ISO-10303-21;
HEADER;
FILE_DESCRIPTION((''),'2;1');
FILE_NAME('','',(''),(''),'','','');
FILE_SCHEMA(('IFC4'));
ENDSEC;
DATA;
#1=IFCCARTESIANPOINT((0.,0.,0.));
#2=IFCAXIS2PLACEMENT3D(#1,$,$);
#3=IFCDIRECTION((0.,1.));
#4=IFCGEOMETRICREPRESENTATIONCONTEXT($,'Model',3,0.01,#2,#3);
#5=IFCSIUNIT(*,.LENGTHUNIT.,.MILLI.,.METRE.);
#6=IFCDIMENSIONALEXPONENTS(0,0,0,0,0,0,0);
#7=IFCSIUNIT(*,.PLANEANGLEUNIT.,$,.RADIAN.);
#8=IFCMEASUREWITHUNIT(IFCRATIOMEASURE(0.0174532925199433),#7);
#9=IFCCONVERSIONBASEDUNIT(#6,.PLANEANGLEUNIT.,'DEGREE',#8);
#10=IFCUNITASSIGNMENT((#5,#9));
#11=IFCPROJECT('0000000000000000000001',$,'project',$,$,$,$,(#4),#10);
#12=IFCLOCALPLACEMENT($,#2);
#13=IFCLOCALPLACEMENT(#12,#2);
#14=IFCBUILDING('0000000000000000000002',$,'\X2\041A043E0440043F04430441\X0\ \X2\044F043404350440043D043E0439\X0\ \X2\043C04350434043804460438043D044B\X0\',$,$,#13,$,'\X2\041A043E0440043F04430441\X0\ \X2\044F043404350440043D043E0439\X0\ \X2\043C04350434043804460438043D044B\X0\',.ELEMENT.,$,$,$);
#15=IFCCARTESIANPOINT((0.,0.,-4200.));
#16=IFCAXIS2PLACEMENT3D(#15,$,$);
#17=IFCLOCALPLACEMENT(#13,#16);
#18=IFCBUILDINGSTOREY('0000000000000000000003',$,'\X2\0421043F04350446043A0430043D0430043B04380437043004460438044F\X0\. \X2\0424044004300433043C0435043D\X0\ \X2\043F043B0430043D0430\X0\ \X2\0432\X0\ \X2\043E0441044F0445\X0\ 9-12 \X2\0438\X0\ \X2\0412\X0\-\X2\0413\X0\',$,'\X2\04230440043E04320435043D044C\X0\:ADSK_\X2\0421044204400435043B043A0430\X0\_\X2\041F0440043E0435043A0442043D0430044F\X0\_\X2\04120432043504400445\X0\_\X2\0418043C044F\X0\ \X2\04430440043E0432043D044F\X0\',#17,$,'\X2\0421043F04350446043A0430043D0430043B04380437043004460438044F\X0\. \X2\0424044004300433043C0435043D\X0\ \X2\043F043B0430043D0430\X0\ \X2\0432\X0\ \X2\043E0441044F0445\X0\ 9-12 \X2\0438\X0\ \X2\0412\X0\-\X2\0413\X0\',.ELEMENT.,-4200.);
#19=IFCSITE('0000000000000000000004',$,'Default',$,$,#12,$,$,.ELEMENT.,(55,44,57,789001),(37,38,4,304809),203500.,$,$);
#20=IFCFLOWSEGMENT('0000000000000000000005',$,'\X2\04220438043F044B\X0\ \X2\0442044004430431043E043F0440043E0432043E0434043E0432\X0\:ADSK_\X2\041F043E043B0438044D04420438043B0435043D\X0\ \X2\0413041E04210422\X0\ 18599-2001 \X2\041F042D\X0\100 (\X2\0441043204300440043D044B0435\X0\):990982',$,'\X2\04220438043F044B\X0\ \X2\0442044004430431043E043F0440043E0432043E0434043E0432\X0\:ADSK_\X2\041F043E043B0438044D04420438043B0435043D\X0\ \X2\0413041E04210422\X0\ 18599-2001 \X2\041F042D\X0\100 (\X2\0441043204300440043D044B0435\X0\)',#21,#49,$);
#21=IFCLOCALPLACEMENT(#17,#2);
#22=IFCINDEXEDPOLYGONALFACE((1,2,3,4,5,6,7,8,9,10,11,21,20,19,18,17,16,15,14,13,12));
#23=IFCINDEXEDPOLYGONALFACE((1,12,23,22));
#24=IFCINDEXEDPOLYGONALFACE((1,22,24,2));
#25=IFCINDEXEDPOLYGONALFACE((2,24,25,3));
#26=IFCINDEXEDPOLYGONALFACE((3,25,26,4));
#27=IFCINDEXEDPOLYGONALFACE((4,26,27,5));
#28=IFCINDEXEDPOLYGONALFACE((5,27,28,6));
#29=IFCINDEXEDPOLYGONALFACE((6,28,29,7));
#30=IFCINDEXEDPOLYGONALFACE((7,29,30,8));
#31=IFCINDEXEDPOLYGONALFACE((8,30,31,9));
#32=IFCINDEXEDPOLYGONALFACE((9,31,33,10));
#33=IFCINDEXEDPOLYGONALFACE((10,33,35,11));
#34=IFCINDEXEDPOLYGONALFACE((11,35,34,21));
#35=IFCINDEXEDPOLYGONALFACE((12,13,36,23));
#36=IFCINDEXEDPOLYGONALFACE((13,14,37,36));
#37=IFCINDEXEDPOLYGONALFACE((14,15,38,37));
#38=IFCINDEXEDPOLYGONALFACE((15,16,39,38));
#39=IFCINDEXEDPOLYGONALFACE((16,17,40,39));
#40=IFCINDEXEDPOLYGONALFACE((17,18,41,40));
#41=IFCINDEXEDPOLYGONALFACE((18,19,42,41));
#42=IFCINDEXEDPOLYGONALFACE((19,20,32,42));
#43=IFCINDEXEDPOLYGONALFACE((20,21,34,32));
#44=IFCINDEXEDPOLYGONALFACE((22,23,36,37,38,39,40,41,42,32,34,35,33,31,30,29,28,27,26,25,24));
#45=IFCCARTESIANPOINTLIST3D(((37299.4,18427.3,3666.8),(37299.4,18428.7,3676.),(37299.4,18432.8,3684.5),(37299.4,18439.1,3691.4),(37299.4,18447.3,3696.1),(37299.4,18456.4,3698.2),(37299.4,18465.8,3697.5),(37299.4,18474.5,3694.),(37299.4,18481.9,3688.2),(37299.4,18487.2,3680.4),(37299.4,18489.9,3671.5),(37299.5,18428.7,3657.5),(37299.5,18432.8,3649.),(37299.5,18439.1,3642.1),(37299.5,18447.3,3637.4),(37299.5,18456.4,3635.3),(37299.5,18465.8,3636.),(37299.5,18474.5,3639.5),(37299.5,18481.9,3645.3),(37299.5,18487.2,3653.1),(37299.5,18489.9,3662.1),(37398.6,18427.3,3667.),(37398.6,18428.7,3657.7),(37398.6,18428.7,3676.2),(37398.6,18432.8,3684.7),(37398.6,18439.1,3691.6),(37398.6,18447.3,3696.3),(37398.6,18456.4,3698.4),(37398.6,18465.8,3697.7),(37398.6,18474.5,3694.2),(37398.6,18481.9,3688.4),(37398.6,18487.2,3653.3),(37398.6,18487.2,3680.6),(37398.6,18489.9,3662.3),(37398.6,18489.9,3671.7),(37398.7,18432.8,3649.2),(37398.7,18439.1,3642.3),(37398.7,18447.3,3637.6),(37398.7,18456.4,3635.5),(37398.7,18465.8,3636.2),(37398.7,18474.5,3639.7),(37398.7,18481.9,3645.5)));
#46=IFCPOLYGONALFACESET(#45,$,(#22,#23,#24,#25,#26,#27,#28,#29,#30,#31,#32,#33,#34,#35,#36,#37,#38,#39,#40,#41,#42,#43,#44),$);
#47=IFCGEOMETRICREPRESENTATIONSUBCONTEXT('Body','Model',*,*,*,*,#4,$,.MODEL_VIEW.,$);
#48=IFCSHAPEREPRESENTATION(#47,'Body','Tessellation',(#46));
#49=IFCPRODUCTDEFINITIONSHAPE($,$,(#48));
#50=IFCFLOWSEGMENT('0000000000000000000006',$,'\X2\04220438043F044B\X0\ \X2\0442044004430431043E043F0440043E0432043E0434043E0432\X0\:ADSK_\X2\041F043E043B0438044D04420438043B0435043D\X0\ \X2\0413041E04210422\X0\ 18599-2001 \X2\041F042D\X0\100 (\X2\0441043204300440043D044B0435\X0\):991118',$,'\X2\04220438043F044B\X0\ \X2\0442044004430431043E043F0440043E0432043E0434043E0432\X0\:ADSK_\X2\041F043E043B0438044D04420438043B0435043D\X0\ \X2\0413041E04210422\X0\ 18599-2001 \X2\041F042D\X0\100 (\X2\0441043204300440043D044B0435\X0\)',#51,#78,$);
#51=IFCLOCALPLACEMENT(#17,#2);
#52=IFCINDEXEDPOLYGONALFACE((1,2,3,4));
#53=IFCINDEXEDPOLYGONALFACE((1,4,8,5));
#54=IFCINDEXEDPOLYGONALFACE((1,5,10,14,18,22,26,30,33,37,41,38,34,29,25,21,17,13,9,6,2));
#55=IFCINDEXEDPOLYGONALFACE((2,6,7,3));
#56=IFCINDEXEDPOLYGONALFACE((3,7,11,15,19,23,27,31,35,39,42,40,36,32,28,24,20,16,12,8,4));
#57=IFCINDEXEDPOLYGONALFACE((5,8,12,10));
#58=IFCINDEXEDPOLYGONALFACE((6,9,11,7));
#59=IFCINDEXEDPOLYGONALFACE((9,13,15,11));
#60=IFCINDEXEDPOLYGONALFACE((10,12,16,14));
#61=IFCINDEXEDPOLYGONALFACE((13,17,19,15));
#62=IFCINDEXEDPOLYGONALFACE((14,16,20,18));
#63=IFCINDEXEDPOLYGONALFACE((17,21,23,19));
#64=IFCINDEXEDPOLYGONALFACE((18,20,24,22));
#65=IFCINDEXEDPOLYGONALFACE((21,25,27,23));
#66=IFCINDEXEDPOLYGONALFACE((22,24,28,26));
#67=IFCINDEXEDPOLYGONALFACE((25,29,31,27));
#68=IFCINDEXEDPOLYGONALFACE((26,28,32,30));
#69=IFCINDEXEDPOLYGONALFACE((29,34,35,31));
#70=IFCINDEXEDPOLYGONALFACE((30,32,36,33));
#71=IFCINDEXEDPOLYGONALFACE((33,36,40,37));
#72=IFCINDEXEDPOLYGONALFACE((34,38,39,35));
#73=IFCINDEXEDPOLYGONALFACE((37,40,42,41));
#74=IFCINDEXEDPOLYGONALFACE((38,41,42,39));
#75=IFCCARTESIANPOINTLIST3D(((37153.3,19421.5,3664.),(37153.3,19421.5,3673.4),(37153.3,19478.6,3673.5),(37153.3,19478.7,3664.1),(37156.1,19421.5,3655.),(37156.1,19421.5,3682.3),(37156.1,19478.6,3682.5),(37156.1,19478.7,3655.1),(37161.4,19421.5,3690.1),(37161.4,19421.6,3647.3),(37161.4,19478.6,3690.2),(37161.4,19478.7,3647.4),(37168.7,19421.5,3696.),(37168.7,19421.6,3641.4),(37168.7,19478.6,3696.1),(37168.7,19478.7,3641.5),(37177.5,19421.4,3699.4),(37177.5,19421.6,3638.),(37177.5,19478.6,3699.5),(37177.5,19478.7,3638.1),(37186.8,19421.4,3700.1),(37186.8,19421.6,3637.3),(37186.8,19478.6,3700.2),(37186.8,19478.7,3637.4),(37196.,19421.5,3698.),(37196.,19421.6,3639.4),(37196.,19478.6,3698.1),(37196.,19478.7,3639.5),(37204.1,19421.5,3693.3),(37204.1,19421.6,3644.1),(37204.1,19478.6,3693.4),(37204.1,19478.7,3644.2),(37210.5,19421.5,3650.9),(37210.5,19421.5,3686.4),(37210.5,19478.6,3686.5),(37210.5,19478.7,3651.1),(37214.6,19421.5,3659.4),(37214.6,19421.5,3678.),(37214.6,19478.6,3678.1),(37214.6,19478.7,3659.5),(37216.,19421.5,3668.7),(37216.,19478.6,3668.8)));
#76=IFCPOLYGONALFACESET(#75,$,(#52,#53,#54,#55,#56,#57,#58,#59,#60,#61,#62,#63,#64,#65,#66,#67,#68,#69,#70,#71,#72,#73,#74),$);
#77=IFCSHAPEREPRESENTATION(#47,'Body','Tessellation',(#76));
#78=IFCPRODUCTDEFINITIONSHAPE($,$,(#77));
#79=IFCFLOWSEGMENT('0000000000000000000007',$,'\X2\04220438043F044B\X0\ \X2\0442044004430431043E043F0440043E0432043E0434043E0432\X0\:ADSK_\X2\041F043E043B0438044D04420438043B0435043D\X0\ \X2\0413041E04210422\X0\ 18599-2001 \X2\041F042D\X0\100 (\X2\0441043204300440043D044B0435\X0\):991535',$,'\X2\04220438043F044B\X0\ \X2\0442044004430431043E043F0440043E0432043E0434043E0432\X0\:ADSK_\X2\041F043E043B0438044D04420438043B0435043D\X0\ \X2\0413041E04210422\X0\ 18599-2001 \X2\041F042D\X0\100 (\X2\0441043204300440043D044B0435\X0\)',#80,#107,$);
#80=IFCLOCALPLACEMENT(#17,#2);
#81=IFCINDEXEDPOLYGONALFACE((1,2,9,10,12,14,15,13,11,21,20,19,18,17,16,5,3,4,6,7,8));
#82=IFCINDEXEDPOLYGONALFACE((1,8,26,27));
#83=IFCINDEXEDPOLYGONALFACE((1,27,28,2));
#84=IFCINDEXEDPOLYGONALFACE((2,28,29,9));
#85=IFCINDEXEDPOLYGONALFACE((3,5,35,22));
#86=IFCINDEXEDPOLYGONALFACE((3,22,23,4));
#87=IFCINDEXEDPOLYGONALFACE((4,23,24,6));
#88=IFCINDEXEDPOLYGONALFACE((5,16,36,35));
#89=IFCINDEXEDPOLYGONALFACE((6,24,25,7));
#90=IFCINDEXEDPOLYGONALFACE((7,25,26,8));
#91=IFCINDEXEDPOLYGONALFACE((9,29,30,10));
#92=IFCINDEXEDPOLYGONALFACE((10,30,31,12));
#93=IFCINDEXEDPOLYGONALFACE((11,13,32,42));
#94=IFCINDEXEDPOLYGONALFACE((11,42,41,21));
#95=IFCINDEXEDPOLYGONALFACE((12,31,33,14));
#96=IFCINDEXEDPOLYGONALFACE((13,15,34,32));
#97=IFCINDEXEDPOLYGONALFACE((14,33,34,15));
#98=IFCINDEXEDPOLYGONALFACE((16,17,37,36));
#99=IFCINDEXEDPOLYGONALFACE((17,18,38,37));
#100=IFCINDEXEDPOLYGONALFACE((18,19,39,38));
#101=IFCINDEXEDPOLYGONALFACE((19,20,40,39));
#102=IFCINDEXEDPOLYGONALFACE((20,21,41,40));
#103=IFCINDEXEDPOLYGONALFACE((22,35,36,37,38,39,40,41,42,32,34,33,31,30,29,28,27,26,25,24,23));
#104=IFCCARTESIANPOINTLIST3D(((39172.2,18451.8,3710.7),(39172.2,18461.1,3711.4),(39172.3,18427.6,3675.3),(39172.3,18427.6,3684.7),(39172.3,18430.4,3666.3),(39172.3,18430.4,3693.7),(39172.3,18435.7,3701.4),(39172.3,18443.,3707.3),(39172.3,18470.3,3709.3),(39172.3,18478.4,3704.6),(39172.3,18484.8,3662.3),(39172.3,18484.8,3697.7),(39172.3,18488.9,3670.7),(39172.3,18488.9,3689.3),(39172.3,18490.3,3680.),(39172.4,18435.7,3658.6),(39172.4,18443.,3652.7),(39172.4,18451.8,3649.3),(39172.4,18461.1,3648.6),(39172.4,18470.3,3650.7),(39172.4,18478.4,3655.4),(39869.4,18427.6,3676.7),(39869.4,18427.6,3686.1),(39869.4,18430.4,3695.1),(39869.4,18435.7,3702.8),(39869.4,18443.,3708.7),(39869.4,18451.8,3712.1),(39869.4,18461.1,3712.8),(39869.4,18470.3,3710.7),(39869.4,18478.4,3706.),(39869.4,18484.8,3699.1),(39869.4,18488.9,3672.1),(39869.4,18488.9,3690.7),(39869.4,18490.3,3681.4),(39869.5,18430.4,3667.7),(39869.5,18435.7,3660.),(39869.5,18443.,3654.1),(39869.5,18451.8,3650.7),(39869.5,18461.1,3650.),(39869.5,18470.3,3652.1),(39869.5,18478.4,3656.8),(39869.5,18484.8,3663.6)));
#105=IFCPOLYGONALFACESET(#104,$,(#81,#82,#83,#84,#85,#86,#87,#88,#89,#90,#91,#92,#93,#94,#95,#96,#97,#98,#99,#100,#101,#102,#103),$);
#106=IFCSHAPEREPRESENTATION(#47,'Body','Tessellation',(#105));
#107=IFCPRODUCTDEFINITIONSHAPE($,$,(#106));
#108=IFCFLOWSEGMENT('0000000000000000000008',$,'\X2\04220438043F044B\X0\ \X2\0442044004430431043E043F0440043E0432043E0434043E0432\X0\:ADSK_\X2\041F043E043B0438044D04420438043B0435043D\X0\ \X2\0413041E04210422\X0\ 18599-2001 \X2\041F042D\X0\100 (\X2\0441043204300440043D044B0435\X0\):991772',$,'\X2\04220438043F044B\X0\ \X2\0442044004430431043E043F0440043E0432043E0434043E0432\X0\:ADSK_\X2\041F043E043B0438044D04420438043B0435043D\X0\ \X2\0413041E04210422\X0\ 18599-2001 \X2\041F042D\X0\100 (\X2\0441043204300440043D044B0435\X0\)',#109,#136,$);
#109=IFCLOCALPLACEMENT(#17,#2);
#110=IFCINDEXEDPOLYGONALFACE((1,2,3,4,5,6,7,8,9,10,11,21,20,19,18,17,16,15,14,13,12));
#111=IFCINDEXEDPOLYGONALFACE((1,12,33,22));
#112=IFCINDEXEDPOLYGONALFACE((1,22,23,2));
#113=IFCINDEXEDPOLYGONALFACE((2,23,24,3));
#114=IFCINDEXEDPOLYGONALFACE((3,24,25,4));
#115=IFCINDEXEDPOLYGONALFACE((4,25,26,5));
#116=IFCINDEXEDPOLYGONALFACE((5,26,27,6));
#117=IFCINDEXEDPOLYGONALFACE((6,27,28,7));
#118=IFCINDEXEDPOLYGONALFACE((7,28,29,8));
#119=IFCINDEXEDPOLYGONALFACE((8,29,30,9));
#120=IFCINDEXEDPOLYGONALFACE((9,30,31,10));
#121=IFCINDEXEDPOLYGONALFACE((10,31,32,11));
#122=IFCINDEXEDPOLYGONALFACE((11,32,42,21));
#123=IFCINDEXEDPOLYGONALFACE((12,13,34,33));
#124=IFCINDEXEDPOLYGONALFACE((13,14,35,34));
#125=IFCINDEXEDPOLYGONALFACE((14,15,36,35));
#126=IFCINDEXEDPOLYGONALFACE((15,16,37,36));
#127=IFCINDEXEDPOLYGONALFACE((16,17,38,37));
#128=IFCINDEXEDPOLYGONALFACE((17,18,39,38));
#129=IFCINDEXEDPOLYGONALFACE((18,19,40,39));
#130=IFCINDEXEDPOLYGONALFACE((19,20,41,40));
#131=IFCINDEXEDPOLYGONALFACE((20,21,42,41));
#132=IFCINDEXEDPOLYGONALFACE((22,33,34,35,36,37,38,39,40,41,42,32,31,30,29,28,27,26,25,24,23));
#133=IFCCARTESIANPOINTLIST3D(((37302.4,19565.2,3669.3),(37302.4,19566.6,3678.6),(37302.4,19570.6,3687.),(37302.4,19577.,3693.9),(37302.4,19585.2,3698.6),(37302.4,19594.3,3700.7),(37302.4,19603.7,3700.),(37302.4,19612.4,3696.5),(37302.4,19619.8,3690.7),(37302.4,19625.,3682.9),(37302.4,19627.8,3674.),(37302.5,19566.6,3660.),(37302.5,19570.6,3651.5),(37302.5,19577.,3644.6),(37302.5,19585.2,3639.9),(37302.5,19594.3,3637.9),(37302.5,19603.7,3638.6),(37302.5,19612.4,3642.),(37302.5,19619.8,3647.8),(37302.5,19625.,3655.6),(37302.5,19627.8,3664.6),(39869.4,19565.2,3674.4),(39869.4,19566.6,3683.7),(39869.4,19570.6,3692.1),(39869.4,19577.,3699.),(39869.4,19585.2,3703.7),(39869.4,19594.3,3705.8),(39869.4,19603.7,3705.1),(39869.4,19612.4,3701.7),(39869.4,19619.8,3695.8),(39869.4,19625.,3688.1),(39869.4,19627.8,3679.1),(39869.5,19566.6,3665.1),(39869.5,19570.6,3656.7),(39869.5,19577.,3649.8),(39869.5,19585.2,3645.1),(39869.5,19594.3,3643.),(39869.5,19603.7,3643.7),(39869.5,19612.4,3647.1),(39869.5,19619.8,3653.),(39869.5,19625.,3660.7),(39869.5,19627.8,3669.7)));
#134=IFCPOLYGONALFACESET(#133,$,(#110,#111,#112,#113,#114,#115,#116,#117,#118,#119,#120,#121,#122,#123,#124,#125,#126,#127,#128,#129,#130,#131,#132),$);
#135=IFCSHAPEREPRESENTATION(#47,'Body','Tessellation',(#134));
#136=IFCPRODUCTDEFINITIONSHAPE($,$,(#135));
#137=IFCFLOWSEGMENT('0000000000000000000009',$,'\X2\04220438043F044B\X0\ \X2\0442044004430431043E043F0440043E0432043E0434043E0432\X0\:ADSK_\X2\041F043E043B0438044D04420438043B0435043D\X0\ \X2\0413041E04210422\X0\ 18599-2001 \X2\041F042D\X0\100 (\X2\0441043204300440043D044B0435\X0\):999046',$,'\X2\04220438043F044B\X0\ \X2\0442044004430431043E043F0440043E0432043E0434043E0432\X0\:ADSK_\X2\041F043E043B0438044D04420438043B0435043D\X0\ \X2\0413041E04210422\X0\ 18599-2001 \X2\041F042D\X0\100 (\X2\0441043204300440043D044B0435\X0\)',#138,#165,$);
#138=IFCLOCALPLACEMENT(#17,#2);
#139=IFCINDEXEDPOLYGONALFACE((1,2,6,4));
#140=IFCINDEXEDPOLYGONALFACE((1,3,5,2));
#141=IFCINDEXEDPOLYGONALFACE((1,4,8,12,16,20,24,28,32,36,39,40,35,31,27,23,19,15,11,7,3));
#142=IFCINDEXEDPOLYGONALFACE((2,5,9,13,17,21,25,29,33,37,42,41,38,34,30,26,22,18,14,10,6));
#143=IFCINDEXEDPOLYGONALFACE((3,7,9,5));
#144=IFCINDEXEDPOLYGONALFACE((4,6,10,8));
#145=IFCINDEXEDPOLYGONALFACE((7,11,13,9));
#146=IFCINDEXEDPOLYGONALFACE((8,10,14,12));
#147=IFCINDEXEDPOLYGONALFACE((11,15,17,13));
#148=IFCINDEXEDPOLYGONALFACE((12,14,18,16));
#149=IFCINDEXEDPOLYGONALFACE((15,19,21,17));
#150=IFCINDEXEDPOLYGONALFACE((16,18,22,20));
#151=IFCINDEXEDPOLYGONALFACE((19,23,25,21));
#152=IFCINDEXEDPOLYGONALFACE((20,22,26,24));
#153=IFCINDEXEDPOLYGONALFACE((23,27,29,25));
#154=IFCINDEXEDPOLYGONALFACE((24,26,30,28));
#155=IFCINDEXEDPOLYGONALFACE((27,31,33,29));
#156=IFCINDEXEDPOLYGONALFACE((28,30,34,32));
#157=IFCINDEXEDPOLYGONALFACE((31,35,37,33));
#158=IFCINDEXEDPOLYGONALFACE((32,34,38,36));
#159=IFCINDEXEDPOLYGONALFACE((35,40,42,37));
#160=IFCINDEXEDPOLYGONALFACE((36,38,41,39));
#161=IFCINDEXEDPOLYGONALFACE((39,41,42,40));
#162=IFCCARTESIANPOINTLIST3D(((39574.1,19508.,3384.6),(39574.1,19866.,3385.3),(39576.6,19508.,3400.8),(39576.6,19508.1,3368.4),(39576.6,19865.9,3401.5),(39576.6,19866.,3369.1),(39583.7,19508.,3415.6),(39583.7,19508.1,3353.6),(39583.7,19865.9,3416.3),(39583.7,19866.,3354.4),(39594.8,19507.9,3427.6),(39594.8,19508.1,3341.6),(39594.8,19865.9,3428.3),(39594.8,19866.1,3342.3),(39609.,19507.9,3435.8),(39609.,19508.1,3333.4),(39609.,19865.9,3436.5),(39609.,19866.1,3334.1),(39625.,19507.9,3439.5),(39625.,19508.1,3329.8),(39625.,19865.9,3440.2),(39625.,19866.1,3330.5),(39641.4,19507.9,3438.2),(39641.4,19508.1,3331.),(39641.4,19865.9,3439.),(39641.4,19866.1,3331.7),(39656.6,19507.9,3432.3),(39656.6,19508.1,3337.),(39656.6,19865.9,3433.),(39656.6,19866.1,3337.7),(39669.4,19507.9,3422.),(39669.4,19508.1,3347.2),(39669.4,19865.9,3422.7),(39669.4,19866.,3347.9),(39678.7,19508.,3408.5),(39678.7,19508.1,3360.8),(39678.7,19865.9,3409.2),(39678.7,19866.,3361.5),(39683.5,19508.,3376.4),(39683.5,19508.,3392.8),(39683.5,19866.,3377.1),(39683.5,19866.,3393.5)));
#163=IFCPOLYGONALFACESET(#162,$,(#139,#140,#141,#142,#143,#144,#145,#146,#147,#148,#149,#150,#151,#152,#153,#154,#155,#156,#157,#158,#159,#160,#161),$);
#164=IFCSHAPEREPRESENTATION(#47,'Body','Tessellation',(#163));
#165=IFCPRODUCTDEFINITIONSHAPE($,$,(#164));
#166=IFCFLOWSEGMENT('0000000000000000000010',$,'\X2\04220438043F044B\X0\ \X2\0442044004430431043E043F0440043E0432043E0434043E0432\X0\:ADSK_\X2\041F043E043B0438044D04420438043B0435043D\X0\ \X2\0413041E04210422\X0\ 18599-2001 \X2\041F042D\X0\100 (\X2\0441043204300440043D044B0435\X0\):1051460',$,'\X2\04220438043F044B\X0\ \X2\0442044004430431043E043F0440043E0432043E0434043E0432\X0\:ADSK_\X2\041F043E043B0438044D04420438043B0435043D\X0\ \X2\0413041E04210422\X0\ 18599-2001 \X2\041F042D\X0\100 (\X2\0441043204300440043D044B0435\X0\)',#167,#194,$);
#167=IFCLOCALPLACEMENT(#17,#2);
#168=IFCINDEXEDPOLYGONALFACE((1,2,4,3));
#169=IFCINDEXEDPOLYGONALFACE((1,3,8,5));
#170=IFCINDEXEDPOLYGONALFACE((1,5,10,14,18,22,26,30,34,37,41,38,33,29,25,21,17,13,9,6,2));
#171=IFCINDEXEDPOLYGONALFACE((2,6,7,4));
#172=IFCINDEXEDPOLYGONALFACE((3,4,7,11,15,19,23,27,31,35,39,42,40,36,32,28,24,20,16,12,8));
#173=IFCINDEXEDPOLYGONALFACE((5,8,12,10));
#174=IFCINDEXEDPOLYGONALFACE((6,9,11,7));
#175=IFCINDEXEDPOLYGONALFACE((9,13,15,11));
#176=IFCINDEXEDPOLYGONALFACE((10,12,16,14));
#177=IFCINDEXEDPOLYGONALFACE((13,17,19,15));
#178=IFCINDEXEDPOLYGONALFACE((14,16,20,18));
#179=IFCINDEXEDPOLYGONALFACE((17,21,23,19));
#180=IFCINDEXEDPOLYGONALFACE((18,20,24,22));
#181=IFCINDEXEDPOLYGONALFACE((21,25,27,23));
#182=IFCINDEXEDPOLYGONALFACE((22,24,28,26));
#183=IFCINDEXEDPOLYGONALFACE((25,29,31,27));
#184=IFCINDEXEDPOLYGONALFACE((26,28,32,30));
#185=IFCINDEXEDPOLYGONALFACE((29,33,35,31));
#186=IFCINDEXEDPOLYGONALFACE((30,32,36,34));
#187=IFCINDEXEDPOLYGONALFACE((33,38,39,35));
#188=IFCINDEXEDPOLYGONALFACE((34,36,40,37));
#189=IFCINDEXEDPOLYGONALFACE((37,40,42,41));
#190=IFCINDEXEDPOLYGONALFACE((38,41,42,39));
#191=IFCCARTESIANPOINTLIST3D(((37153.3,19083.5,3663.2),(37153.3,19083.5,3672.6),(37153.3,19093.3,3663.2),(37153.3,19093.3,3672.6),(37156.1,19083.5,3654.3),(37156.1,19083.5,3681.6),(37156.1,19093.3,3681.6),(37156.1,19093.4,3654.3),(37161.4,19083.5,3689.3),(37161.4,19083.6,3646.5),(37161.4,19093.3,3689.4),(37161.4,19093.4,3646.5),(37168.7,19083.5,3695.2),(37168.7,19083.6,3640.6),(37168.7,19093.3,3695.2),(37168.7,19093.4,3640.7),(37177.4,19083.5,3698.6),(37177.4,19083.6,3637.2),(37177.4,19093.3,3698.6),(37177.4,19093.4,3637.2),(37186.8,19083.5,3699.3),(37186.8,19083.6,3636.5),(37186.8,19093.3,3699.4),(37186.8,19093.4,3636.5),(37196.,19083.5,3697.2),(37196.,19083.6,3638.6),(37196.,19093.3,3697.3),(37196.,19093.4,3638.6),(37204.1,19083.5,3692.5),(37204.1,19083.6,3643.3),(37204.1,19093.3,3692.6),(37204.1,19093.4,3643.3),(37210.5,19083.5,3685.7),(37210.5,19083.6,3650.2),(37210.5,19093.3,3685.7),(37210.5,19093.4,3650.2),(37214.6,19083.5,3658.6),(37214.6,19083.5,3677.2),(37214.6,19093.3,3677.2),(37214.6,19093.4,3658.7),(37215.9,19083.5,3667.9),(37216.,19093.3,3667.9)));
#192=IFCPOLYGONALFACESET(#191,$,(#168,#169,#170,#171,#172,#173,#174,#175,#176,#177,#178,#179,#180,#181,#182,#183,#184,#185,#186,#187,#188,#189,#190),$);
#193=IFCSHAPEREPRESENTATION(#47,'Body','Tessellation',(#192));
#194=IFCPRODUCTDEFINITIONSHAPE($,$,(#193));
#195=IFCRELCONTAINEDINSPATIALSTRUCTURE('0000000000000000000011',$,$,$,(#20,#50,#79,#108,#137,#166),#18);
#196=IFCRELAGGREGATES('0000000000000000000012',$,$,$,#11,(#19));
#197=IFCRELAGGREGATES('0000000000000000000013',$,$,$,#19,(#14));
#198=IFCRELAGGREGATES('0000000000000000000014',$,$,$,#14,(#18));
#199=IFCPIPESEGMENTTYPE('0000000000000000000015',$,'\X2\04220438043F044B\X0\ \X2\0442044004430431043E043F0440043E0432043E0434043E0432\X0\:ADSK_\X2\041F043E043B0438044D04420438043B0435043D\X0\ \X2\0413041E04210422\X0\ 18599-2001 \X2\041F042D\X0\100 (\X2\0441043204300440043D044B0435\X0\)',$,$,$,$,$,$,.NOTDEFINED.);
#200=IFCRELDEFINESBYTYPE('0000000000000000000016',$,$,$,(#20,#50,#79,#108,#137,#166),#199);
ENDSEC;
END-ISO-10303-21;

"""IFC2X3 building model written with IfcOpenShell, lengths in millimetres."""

from ifc_helpers import new_model, entity, si_unit, converted_unit, direction, frame, origin, origin_2d_with_axis, place, context, subcontext, project, spatial, circle, extrude, type_object, element, save


model = new_model("IFC2X3")

# Units and contexts
model_context = context("Model", 3, precision=0.01, world=origin(), true_north=direction((0.0, 1.0)))
body_context = subcontext(model_context, "Body", "Model", "MODEL_VIEW")
ifc_project = project(units=[si_unit("LENGTHUNIT", "METRE", prefix="MILLI"), converted_unit("PLANEANGLEUNIT", "DEGREE", entity("IfcRatioMeasure", 0.0174532925199433), si_unit("PLANEANGLEUNIT", "RADIAN"), dimensions=[0, 0, 0, 0, 0, 0, 0])], contexts=[model_context])

# Site, building, storey
site_placement = place(None, origin())
site = spatial("IfcSite", under=ifc_project, at=site_placement, Name="Default", CompositionType="ELEMENT", RefLatitude=(55, 44, 57, 789001), RefLongitude=(37, 38, 4, 304809), RefElevation=203500.0)
building_placement = place(site_placement, origin())
building = spatial("IfcBuilding", under=site, at=building_placement, Name="Корпус ядерной медицины", LongName="Корпус ядерной медицины", CompositionType="ELEMENT")
storey_placement = place(building_placement, frame((0.0, 0.0, -4200.0)))
storey = spatial("IfcBuildingStorey", under=building, at=storey_placement, Name="Спецканализация. Фрагмен плана в осях 9-12 и В-Г", ObjectType="Уровень:ADSK_Стрелка_Проектная_Вверх_Имя уровня", LongName="Спецканализация. Фрагмен плана в осях 9-12 и В-Г", CompositionType="ELEMENT", Elevation=-4200.0)

# Flow segments
pipe_segment_type = type_object("IfcPipeSegmentType", Name="Типы трубопроводов:ADSK_Полиэтилен ГОСТ 18599-2001 ПЭ100 (сварные)", PredefinedType="NOTDEFINED")
flow_segment_1_placement = place(storey_placement, frame((37299.4, 18425.7, 3633.7)))
element("IfcFlowSegment", 1, at=flow_segment_1_placement, inside=storey, type_object=pipe_segment_type, Name="Типы трубопроводов:ADSK_Полиэтилен ГОСТ 18599-2001 ПЭ100 (сварные):990982", ObjectType="Типы трубопроводов:ADSK_Полиэтилен ГОСТ 18599-2001 ПЭ100 (сварные)", context=body_context, shape_type="SweptSolid", body=[
    extrude(circle(Radius=31.5, at=origin_2d_with_axis()), frame((0.1, 33.1, 33.1), z_axis=(0.999998, 0.0, 0.001997), x_axis=(0.0, -1.0, 0.0)), (0.0, 0.0, 1.0), 99.2),
])
flow_segment_2_placement = place(storey_placement, frame((37151.4, 19421.5, 3635.6)))
element("IfcFlowSegment", 2, at=flow_segment_2_placement, inside=storey, type_object=pipe_segment_type, Name="Типы трубопроводов:ADSK_Полиэтилен ГОСТ 18599-2001 ПЭ100 (сварные):991118", ObjectType="Типы трубопроводов:ADSK_Полиэтилен ГОСТ 18599-2001 ПЭ100 (сварные)", context=body_context, shape_type="SweptSolid", body=[
    extrude(circle(Radius=31.5, at=origin_2d_with_axis()), frame((33.1, 0.1, 33.1), z_axis=(0.0, 0.999998, 0.002007), x_axis=(1.0, 0.0, 0.0)), (0.0, 0.0, 1.0), 57.1),
])
flow_segment_3_placement = place(storey_placement, frame((39172.2, 18425.7, 3646.9)))
element("IfcFlowSegment", 3, at=flow_segment_3_placement, inside=storey, type_object=pipe_segment_type, Name="Типы трубопроводов:ADSK_Полиэтилен ГОСТ 18599-2001 ПЭ100 (сварные):991535", ObjectType="Типы трубопроводов:ADSK_Полиэтилен ГОСТ 18599-2001 ПЭ100 (сварные)", context=body_context, shape_type="SweptSolid", body=[
    extrude(circle(Radius=31.5, at=origin_2d_with_axis()), frame((0.1, 33.1, 33.1), z_axis=(0.999998, 0.0, 0.001997), x_axis=(0.0, 1.0, 0.0)), (0.0, 0.0, 1.0), 697.1),
])
flow_segment_4_placement = place(storey_placement, frame((37302.4, 19563.6, 3636.2)))
element("IfcFlowSegment", 4, at=flow_segment_4_placement, inside=storey, type_object=pipe_segment_type, Name="Типы трубопроводов:ADSK_Полиэтилен ГОСТ 18599-2001 ПЭ100 (сварные):991772", ObjectType="Типы трубопроводов:ADSK_Полиэтилен ГОСТ 18599-2001 ПЭ100 (сварные)", context=body_context, shape_type="SweptSolid", body=[
    extrude(circle(Radius=31.5, at=origin_2d_with_axis()), frame((0.1, 33.1, 33.1), z_axis=(0.999998, 0.0, 0.002), x_axis=(0.0, -1.0, 0.0)), (0.0, 0.0, 1.0), 2567.0),
])
flow_segment_5_placement = place(storey_placement, frame((39572.5, 19507.9, 3328.0)))
element("IfcFlowSegment", 5, at=flow_segment_5_placement, inside=storey, type_object=pipe_segment_type, Name="Типы трубопроводов:ADSK_Полиэтилен ГОСТ 18599-2001 ПЭ100 (сварные):999046", ObjectType="Типы трубопроводов:ADSK_Полиэтилен ГОСТ 18599-2001 ПЭ100 (сварные)", context=body_context, shape_type="SweptSolid", body=[
    extrude(circle(Radius=55.0, at=origin_2d_with_axis()), frame((56.6, 0.1, 56.6), z_axis=(-0.000004, 0.999998, 0.002), x_axis=(-1.0, -0.000004, 0.0)), (0.0, 0.0, 1.0), 358.0),
])
flow_segment_6_placement = place(storey_placement, frame((37151.3, 19083.5, 3634.8)))
element("IfcFlowSegment", 6, at=flow_segment_6_placement, inside=storey, type_object=pipe_segment_type, Name="Типы трубопроводов:ADSK_Полиэтилен ГОСТ 18599-2001 ПЭ100 (сварные):1051460", ObjectType="Типы трубопроводов:ADSK_Полиэтилен ГОСТ 18599-2001 ПЭ100 (сварные)", context=body_context, shape_type="SweptSolid", body=[
    extrude(circle(Radius=31.5, at=origin_2d_with_axis()), frame((33.1, 0.1, 33.1), z_axis=(0.000001, 0.999998, 0.002), x_axis=(1.0, -0.000001, 0.0)), (0.0, 0.0, 1.0), 9.8),
])

save(model, "model.ifc")
